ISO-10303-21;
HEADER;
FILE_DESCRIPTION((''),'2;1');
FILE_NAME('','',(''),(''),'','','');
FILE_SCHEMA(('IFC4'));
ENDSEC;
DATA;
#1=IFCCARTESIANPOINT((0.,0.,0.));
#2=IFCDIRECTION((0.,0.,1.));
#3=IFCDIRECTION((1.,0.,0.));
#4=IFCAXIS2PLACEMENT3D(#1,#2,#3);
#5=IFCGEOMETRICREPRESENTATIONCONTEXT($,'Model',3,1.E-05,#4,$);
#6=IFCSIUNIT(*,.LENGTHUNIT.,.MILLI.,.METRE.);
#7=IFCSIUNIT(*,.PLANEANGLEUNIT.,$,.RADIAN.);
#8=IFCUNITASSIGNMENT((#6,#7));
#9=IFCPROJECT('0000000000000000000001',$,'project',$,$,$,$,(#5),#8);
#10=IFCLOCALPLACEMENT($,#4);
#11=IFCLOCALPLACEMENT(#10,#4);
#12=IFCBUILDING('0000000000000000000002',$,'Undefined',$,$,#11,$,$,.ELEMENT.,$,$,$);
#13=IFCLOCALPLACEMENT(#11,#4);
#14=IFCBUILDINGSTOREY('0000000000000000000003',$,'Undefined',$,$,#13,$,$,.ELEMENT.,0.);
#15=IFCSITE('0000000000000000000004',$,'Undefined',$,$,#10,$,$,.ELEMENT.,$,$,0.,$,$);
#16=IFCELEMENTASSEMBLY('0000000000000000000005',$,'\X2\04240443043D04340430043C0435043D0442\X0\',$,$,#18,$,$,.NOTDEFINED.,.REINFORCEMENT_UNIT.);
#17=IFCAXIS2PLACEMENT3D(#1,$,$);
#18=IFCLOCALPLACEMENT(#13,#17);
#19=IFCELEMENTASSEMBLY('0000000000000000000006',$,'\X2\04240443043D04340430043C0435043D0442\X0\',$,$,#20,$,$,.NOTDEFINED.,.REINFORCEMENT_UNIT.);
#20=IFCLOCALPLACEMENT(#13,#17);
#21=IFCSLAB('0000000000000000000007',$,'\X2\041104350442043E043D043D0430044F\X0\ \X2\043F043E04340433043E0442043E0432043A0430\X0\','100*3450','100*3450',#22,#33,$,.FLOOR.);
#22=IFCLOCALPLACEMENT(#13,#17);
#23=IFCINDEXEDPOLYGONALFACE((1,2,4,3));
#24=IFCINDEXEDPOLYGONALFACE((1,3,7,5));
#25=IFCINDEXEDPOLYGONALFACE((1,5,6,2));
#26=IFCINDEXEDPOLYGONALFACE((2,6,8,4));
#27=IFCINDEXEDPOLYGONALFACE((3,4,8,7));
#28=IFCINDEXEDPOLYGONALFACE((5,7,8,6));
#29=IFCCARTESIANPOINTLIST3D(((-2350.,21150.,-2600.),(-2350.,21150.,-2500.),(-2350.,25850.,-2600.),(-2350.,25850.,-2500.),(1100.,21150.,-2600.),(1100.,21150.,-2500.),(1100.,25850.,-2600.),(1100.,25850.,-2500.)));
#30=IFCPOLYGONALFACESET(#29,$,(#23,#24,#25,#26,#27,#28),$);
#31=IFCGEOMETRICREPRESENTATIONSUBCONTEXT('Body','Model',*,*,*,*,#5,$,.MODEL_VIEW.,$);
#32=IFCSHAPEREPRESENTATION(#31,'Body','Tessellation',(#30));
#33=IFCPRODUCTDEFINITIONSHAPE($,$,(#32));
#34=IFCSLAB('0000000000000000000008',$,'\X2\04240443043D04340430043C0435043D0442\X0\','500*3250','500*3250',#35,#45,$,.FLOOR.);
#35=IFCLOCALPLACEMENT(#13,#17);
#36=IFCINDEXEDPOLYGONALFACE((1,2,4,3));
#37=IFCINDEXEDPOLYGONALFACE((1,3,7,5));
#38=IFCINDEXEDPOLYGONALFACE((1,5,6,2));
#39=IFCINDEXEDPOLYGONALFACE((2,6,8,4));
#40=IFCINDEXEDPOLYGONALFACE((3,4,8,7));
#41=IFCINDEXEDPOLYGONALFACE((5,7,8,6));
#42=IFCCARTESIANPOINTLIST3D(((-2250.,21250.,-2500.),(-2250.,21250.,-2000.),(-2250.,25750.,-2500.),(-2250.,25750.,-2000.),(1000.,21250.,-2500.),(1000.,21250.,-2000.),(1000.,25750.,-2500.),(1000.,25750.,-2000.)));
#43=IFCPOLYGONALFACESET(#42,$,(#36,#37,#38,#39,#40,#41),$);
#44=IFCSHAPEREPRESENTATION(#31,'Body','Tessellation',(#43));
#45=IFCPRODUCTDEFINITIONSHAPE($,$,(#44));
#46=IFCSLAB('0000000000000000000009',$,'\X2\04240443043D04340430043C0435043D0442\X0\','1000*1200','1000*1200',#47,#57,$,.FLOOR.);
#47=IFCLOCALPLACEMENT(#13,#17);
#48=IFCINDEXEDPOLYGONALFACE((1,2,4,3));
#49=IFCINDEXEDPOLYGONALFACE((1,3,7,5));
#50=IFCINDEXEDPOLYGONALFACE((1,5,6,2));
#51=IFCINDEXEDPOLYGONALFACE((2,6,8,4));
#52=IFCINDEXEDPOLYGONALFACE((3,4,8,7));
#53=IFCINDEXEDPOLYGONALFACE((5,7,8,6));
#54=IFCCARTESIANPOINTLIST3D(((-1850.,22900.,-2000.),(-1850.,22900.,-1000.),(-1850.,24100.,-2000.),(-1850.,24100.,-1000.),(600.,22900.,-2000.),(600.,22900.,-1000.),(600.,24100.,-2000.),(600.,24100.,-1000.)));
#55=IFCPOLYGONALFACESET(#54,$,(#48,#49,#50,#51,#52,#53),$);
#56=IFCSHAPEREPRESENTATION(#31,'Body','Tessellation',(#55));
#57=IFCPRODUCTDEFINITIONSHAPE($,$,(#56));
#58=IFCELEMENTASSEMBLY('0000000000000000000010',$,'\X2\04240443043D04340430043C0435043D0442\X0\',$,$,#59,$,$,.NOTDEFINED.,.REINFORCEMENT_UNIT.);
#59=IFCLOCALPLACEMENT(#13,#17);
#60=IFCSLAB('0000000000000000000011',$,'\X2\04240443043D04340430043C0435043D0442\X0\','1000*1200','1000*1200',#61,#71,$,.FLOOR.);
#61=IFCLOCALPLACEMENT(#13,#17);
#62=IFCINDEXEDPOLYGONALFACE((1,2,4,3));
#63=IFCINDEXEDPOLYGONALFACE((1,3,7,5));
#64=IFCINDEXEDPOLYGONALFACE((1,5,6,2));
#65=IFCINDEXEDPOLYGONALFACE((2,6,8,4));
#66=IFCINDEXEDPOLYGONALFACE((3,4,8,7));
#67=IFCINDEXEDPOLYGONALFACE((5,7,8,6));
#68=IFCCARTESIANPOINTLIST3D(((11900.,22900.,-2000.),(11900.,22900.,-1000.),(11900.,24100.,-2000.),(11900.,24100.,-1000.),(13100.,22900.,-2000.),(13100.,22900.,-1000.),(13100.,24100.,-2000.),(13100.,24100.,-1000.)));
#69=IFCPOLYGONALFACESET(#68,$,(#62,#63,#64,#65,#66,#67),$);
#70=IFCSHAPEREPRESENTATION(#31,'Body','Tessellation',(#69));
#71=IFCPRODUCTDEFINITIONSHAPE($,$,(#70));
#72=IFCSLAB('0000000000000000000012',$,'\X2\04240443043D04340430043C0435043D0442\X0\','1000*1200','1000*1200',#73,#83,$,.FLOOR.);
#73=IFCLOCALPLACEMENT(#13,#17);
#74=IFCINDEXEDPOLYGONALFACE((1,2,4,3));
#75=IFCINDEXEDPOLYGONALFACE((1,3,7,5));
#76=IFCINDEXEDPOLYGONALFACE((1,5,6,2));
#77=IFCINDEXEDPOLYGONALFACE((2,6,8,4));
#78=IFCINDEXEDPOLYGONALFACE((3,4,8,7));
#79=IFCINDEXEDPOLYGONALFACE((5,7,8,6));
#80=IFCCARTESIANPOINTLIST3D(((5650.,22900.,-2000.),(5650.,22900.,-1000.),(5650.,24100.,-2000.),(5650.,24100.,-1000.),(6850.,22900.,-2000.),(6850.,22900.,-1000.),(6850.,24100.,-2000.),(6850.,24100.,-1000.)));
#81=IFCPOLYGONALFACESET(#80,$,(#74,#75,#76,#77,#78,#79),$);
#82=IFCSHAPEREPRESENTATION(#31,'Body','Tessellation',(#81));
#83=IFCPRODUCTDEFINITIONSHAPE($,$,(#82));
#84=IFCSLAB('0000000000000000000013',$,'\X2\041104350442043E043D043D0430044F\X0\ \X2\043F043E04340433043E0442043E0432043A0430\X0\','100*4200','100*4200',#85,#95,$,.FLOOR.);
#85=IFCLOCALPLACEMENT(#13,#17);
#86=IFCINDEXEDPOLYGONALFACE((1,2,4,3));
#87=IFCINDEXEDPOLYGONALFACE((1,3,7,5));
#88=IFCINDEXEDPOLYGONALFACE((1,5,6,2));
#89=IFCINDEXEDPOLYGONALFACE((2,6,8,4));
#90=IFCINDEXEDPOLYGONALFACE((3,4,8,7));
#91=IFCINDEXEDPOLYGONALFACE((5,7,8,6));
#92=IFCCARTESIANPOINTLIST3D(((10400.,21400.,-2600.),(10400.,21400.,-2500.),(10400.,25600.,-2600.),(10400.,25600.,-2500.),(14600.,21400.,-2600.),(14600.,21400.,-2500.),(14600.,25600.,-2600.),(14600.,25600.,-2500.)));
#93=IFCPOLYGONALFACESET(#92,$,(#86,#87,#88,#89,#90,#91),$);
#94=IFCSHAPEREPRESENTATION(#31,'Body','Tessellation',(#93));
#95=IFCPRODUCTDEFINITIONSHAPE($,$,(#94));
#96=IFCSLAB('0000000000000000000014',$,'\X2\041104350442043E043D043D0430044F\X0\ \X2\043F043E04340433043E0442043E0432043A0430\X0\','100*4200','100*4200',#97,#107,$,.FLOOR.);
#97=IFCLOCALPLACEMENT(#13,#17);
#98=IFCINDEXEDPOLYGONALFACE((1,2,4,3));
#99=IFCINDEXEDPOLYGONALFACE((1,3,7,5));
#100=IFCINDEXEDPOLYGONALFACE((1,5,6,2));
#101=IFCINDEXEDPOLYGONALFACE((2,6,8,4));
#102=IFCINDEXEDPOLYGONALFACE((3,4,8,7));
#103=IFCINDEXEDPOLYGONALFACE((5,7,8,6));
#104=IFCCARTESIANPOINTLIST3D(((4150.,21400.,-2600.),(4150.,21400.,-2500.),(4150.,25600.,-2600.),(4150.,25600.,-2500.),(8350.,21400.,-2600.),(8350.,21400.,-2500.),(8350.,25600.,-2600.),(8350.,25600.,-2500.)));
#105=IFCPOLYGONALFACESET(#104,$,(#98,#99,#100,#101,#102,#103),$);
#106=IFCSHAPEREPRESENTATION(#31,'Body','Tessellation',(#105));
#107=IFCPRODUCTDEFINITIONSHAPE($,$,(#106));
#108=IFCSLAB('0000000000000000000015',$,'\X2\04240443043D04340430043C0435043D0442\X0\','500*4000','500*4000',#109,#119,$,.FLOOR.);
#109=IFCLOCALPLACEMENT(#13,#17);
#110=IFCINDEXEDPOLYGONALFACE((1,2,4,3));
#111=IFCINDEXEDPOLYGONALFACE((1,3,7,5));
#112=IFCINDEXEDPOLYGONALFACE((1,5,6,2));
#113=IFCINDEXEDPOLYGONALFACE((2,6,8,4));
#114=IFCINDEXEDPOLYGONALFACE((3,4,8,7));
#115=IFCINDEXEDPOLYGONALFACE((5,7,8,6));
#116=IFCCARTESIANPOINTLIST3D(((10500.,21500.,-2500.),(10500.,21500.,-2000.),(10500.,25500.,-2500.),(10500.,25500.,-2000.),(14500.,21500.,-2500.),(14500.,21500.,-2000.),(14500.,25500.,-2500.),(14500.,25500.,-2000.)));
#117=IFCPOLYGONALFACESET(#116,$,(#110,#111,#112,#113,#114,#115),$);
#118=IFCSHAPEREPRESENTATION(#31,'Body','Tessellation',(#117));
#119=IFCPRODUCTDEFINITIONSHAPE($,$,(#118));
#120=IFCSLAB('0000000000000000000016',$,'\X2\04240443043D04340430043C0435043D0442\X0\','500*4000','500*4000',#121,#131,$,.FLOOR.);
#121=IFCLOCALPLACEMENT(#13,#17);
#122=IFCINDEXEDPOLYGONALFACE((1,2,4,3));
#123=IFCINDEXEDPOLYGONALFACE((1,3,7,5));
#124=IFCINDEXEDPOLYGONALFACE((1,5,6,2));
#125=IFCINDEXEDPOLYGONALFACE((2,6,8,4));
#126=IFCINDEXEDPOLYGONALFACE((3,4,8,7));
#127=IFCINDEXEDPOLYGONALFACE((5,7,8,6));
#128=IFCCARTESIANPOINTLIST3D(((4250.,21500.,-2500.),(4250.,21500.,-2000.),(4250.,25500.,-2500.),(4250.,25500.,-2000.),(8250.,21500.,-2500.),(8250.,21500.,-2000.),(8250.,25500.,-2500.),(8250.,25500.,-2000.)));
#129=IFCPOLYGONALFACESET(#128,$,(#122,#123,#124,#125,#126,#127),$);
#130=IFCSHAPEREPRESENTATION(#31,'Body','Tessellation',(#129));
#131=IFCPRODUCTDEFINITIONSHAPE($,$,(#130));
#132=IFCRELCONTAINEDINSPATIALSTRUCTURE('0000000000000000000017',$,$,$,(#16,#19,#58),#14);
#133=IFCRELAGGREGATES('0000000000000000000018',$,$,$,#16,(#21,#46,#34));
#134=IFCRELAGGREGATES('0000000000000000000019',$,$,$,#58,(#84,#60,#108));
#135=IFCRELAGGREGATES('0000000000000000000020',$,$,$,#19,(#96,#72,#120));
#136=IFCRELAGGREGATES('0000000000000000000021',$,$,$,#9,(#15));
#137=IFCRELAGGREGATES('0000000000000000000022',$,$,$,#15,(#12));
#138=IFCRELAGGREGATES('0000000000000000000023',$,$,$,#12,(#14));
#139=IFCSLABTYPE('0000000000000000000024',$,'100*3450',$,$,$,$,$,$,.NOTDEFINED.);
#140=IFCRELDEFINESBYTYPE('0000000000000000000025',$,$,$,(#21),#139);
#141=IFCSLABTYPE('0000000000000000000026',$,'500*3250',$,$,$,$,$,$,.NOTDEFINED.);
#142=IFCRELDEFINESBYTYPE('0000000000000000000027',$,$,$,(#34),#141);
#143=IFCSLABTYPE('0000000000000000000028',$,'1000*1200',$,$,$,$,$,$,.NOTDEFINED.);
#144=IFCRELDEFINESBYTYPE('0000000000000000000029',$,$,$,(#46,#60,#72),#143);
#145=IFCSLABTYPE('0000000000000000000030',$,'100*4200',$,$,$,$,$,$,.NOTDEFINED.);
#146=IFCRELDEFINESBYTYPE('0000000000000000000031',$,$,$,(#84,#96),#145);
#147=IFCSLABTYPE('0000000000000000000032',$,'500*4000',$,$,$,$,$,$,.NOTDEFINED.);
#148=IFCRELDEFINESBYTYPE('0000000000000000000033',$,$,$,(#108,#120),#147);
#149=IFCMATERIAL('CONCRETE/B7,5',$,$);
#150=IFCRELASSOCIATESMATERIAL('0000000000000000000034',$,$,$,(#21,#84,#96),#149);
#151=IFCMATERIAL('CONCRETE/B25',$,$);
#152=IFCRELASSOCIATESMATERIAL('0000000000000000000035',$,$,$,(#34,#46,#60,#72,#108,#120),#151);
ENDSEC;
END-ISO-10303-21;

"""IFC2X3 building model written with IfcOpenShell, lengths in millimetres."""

from ifc_helpers import new_model, si_unit, frame, origin_with_axes, place, context, subcontext, project, spatial, polyline, outline, extrude, material, type_object, element, aggregate, save


model = new_model("IFC2X3")

# Units and contexts
model_context = context("Model", 3, precision=1e-05, world=origin_with_axes())
body_context = subcontext(model_context, "Body", "Model", "MODEL_VIEW")
ifc_project = project(units=[si_unit("LENGTHUNIT", "METRE", prefix="MILLI"), si_unit("PLANEANGLEUNIT", "RADIAN")], contexts=[model_context])

# Site, building, storey
site_placement = place(None, origin_with_axes())
site = spatial("IfcSite", under=ifc_project, at=site_placement, Name="Undefined", CompositionType="ELEMENT", RefElevation=0.0)
building_placement = place(site_placement, origin_with_axes())
building = spatial("IfcBuilding", under=site, at=building_placement, Name="Undefined", CompositionType="ELEMENT")
storey_placement = place(building_placement, origin_with_axes())
storey = spatial("IfcBuildingStorey", under=building, at=storey_placement, Name="Undefined", CompositionType="ELEMENT", Elevation=0.0)

# Element assemblies
assembly_1_placement = place(storey_placement, origin_with_axes())
assembly_1 = element("IfcElementAssembly", 1, at=assembly_1_placement, inside=storey, Name="Фундамент", AssemblyPlace="NOTDEFINED", PredefinedType="REINFORCEMENT_UNIT")
ifc_material_1 = material(Name="CONCRETE/B25")
assembly_2_placement = place(storey_placement, origin_with_axes())
assembly_2 = element("IfcElementAssembly", 2, at=assembly_2_placement, inside=storey, Name="Фундамент", AssemblyPlace="NOTDEFINED", PredefinedType="REINFORCEMENT_UNIT")

# Shared definitions
ifc_material_2 = material(Name="CONCRETE/B7,5")

# Slabs
slab_type_1 = type_object("IfcSlabType", Name="100*3450", PredefinedType="NOTDEFINED")
slab_1_placement = place(assembly_1_placement, frame((-2350.0, 25850.0, -2550.0), z_axis=(0.0, 0.0, 1.0), x_axis=(0.0, -1.0, 0.0)))
slab_1 = element("IfcSlab", 3, at=slab_1_placement, type_object=slab_type_1, material=ifc_material_2, Name="Бетонная подготовка", Description="100*3450", ObjectType="100*3450", PredefinedType="FLOOR", context=body_context, shape_type="SweptSolid", body=[
    extrude(outline(polyline([(0.0, 0.0), (4700.0, 0.0), (4700.0, 3450.0), (0.0, 3450.0), (0.0, 0.0)])), frame((0.0, 0.0, -50.0), z_axis=(0.0, 0.0, 1.0), x_axis=(1.0, 0.0, 0.0)), (0.0, 0.0, 1.0), 100.0),
])
slab_type_2 = type_object("IfcSlabType", Name="500*3250", PredefinedType="NOTDEFINED")
slab_2_placement = place(assembly_1_placement, frame((-2250.0, 25750.0, -2250.0), z_axis=(0.0, 0.0, 1.0), x_axis=(0.0, -1.0, 0.0)))
slab_2 = element("IfcSlab", 4, at=slab_2_placement, type_object=slab_type_2, material=ifc_material_1, Name="Фундамент", Description="500*3250", ObjectType="500*3250", PredefinedType="FLOOR", context=body_context, shape_type="SweptSolid", body=[
    extrude(outline(polyline([(0.0, 0.0), (4500.0, 0.0), (4500.0, 3250.0), (0.0, 3250.0), (0.0, 0.0)])), frame((0.0, 0.0, -250.0), z_axis=(0.0, 0.0, 1.0), x_axis=(1.0, 0.0, 0.0)), (0.0, 0.0, 1.0), 500.0),
])
slab_type_3 = type_object("IfcSlabType", Name="1000*1200", PredefinedType="NOTDEFINED")
slab_3_placement = place(assembly_1_placement, frame((-1850.0, 24100.0, -1500.0), z_axis=(0.0, 0.0, 1.0), x_axis=(0.0, -1.0, 0.0)))
slab_3 = element("IfcSlab", 5, at=slab_3_placement, type_object=slab_type_3, material=ifc_material_1, Name="Фундамент", Description="1000*1200", ObjectType="1000*1200", PredefinedType="FLOOR", context=body_context, shape_type="SweptSolid", body=[
    extrude(outline(polyline([(0.0, 0.0), (1200.0, 0.0), (1200.0, 2450.0), (0.0, 2450.0), (0.0, 0.0)])), frame((0.0, 0.0, -500.0), z_axis=(0.0, 0.0, 1.0), x_axis=(1.0, 0.0, 0.0)), (0.0, 0.0, 1.0), 1000.0),
])
aggregate(assembly_1, [slab_1, slab_3, slab_2])

# Element assembly, slab
assembly_3_placement = place(storey_placement, origin_with_axes())
assembly_3 = element("IfcElementAssembly", 6, at=assembly_3_placement, inside=storey, Name="Фундамент", AssemblyPlace="NOTDEFINED", PredefinedType="REINFORCEMENT_UNIT")
slab_4_placement = place(assembly_3_placement, frame((11900.0, 24100.0, -1500.0), z_axis=(0.0, 0.0, 1.0), x_axis=(0.0, -1.0, 0.0)))
slab_4 = element("IfcSlab", 7, at=slab_4_placement, type_object=slab_type_3, material=ifc_material_1, Name="Фундамент", Description="1000*1200", ObjectType="1000*1200", PredefinedType="FLOOR", context=body_context, shape_type="SweptSolid", body=[
    extrude(outline(polyline([(0.0, 0.0), (1200.0, 0.0), (1200.0, 1200.0), (0.0, 1200.0), (0.0, 0.0)])), frame((0.0, 0.0, -500.0), z_axis=(0.0, 0.0, 1.0), x_axis=(1.0, 0.0, 0.0)), (0.0, 0.0, 1.0), 1000.0),
])

# Slabs
slab_5_placement = place(assembly_2_placement, frame((5650.0, 24100.0, -1500.0), z_axis=(0.0, 0.0, 1.0), x_axis=(0.0, -1.0, 0.0)))
slab_5 = element("IfcSlab", 8, at=slab_5_placement, type_object=slab_type_3, material=ifc_material_1, Name="Фундамент", Description="1000*1200", ObjectType="1000*1200", PredefinedType="FLOOR", context=body_context, shape_type="SweptSolid", body=[
    extrude(outline(polyline([(0.0, 0.0), (1200.0, 0.0), (1200.0, 1200.0), (0.0, 1200.0), (0.0, 0.0)])), frame((0.0, 0.0, -500.0), z_axis=(0.0, 0.0, 1.0), x_axis=(1.0, 0.0, 0.0)), (0.0, 0.0, 1.0), 1000.0),
])
slab_type_4 = type_object("IfcSlabType", Name="100*4200", PredefinedType="NOTDEFINED")
slab_6_placement = place(assembly_3_placement, frame((10400.0, 25600.0, -2550.0), z_axis=(0.0, 0.0, 1.0), x_axis=(0.0, -1.0, 0.0)))
slab_6 = element("IfcSlab", 9, at=slab_6_placement, type_object=slab_type_4, material=ifc_material_2, Name="Бетонная подготовка", Description="100*4200", ObjectType="100*4200", PredefinedType="FLOOR", context=body_context, shape_type="SweptSolid", body=[
    extrude(outline(polyline([(0.0, 0.0), (4200.0, 0.0), (4200.0, 4200.0), (0.0, 4200.0), (0.0, 0.0)])), frame((0.0, 0.0, -50.0), z_axis=(0.0, 0.0, 1.0), x_axis=(1.0, 0.0, 0.0)), (0.0, 0.0, 1.0), 100.0),
])
slab_7_placement = place(assembly_2_placement, frame((4150.0, 25600.0, -2550.0), z_axis=(0.0, 0.0, 1.0), x_axis=(0.0, -1.0, 0.0)))
slab_7 = element("IfcSlab", 10, at=slab_7_placement, type_object=slab_type_4, material=ifc_material_2, Name="Бетонная подготовка", Description="100*4200", ObjectType="100*4200", PredefinedType="FLOOR", context=body_context, shape_type="SweptSolid", body=[
    extrude(outline(polyline([(0.0, 0.0), (4200.0, 0.0), (4200.0, 4200.0), (0.0, 4200.0), (0.0, 0.0)])), frame((0.0, 0.0, -50.0), z_axis=(0.0, 0.0, 1.0), x_axis=(1.0, 0.0, 0.0)), (0.0, 0.0, 1.0), 100.0),
])
slab_type_5 = type_object("IfcSlabType", Name="500*4000", PredefinedType="NOTDEFINED")
slab_8_placement = place(assembly_3_placement, frame((10500.0, 25500.0, -2250.0), z_axis=(0.0, 0.0, 1.0), x_axis=(0.0, -1.0, 0.0)))
slab_8 = element("IfcSlab", 11, at=slab_8_placement, type_object=slab_type_5, material=ifc_material_1, Name="Фундамент", Description="500*4000", ObjectType="500*4000", PredefinedType="FLOOR", context=body_context, shape_type="SweptSolid", body=[
    extrude(outline(polyline([(0.0, 0.0), (4000.0, 0.0), (4000.0, 4000.0), (0.0, 4000.0), (0.0, 0.0)])), frame((0.0, 0.0, -250.0), z_axis=(0.0, 0.0, 1.0), x_axis=(1.0, 0.0, 0.0)), (0.0, 0.0, 1.0), 500.0),
])
aggregate(assembly_3, [slab_6, slab_4, slab_8])
slab_9_placement = place(assembly_2_placement, frame((4250.0, 25500.0, -2250.0), z_axis=(0.0, 0.0, 1.0), x_axis=(0.0, -1.0, 0.0)))
slab_9 = element("IfcSlab", 12, at=slab_9_placement, type_object=slab_type_5, material=ifc_material_1, Name="Фундамент", Description="500*4000", ObjectType="500*4000", PredefinedType="FLOOR", context=body_context, shape_type="SweptSolid", body=[
    extrude(outline(polyline([(0.0, 0.0), (4000.0, 0.0), (4000.0, 4000.0), (0.0, 4000.0), (0.0, 0.0)])), frame((0.0, 0.0, -250.0), z_axis=(0.0, 0.0, 1.0), x_axis=(1.0, 0.0, 0.0)), (0.0, 0.0, 1.0), 500.0),
])
aggregate(assembly_2, [slab_7, slab_5, slab_9])

save(model, "model.ifc")
